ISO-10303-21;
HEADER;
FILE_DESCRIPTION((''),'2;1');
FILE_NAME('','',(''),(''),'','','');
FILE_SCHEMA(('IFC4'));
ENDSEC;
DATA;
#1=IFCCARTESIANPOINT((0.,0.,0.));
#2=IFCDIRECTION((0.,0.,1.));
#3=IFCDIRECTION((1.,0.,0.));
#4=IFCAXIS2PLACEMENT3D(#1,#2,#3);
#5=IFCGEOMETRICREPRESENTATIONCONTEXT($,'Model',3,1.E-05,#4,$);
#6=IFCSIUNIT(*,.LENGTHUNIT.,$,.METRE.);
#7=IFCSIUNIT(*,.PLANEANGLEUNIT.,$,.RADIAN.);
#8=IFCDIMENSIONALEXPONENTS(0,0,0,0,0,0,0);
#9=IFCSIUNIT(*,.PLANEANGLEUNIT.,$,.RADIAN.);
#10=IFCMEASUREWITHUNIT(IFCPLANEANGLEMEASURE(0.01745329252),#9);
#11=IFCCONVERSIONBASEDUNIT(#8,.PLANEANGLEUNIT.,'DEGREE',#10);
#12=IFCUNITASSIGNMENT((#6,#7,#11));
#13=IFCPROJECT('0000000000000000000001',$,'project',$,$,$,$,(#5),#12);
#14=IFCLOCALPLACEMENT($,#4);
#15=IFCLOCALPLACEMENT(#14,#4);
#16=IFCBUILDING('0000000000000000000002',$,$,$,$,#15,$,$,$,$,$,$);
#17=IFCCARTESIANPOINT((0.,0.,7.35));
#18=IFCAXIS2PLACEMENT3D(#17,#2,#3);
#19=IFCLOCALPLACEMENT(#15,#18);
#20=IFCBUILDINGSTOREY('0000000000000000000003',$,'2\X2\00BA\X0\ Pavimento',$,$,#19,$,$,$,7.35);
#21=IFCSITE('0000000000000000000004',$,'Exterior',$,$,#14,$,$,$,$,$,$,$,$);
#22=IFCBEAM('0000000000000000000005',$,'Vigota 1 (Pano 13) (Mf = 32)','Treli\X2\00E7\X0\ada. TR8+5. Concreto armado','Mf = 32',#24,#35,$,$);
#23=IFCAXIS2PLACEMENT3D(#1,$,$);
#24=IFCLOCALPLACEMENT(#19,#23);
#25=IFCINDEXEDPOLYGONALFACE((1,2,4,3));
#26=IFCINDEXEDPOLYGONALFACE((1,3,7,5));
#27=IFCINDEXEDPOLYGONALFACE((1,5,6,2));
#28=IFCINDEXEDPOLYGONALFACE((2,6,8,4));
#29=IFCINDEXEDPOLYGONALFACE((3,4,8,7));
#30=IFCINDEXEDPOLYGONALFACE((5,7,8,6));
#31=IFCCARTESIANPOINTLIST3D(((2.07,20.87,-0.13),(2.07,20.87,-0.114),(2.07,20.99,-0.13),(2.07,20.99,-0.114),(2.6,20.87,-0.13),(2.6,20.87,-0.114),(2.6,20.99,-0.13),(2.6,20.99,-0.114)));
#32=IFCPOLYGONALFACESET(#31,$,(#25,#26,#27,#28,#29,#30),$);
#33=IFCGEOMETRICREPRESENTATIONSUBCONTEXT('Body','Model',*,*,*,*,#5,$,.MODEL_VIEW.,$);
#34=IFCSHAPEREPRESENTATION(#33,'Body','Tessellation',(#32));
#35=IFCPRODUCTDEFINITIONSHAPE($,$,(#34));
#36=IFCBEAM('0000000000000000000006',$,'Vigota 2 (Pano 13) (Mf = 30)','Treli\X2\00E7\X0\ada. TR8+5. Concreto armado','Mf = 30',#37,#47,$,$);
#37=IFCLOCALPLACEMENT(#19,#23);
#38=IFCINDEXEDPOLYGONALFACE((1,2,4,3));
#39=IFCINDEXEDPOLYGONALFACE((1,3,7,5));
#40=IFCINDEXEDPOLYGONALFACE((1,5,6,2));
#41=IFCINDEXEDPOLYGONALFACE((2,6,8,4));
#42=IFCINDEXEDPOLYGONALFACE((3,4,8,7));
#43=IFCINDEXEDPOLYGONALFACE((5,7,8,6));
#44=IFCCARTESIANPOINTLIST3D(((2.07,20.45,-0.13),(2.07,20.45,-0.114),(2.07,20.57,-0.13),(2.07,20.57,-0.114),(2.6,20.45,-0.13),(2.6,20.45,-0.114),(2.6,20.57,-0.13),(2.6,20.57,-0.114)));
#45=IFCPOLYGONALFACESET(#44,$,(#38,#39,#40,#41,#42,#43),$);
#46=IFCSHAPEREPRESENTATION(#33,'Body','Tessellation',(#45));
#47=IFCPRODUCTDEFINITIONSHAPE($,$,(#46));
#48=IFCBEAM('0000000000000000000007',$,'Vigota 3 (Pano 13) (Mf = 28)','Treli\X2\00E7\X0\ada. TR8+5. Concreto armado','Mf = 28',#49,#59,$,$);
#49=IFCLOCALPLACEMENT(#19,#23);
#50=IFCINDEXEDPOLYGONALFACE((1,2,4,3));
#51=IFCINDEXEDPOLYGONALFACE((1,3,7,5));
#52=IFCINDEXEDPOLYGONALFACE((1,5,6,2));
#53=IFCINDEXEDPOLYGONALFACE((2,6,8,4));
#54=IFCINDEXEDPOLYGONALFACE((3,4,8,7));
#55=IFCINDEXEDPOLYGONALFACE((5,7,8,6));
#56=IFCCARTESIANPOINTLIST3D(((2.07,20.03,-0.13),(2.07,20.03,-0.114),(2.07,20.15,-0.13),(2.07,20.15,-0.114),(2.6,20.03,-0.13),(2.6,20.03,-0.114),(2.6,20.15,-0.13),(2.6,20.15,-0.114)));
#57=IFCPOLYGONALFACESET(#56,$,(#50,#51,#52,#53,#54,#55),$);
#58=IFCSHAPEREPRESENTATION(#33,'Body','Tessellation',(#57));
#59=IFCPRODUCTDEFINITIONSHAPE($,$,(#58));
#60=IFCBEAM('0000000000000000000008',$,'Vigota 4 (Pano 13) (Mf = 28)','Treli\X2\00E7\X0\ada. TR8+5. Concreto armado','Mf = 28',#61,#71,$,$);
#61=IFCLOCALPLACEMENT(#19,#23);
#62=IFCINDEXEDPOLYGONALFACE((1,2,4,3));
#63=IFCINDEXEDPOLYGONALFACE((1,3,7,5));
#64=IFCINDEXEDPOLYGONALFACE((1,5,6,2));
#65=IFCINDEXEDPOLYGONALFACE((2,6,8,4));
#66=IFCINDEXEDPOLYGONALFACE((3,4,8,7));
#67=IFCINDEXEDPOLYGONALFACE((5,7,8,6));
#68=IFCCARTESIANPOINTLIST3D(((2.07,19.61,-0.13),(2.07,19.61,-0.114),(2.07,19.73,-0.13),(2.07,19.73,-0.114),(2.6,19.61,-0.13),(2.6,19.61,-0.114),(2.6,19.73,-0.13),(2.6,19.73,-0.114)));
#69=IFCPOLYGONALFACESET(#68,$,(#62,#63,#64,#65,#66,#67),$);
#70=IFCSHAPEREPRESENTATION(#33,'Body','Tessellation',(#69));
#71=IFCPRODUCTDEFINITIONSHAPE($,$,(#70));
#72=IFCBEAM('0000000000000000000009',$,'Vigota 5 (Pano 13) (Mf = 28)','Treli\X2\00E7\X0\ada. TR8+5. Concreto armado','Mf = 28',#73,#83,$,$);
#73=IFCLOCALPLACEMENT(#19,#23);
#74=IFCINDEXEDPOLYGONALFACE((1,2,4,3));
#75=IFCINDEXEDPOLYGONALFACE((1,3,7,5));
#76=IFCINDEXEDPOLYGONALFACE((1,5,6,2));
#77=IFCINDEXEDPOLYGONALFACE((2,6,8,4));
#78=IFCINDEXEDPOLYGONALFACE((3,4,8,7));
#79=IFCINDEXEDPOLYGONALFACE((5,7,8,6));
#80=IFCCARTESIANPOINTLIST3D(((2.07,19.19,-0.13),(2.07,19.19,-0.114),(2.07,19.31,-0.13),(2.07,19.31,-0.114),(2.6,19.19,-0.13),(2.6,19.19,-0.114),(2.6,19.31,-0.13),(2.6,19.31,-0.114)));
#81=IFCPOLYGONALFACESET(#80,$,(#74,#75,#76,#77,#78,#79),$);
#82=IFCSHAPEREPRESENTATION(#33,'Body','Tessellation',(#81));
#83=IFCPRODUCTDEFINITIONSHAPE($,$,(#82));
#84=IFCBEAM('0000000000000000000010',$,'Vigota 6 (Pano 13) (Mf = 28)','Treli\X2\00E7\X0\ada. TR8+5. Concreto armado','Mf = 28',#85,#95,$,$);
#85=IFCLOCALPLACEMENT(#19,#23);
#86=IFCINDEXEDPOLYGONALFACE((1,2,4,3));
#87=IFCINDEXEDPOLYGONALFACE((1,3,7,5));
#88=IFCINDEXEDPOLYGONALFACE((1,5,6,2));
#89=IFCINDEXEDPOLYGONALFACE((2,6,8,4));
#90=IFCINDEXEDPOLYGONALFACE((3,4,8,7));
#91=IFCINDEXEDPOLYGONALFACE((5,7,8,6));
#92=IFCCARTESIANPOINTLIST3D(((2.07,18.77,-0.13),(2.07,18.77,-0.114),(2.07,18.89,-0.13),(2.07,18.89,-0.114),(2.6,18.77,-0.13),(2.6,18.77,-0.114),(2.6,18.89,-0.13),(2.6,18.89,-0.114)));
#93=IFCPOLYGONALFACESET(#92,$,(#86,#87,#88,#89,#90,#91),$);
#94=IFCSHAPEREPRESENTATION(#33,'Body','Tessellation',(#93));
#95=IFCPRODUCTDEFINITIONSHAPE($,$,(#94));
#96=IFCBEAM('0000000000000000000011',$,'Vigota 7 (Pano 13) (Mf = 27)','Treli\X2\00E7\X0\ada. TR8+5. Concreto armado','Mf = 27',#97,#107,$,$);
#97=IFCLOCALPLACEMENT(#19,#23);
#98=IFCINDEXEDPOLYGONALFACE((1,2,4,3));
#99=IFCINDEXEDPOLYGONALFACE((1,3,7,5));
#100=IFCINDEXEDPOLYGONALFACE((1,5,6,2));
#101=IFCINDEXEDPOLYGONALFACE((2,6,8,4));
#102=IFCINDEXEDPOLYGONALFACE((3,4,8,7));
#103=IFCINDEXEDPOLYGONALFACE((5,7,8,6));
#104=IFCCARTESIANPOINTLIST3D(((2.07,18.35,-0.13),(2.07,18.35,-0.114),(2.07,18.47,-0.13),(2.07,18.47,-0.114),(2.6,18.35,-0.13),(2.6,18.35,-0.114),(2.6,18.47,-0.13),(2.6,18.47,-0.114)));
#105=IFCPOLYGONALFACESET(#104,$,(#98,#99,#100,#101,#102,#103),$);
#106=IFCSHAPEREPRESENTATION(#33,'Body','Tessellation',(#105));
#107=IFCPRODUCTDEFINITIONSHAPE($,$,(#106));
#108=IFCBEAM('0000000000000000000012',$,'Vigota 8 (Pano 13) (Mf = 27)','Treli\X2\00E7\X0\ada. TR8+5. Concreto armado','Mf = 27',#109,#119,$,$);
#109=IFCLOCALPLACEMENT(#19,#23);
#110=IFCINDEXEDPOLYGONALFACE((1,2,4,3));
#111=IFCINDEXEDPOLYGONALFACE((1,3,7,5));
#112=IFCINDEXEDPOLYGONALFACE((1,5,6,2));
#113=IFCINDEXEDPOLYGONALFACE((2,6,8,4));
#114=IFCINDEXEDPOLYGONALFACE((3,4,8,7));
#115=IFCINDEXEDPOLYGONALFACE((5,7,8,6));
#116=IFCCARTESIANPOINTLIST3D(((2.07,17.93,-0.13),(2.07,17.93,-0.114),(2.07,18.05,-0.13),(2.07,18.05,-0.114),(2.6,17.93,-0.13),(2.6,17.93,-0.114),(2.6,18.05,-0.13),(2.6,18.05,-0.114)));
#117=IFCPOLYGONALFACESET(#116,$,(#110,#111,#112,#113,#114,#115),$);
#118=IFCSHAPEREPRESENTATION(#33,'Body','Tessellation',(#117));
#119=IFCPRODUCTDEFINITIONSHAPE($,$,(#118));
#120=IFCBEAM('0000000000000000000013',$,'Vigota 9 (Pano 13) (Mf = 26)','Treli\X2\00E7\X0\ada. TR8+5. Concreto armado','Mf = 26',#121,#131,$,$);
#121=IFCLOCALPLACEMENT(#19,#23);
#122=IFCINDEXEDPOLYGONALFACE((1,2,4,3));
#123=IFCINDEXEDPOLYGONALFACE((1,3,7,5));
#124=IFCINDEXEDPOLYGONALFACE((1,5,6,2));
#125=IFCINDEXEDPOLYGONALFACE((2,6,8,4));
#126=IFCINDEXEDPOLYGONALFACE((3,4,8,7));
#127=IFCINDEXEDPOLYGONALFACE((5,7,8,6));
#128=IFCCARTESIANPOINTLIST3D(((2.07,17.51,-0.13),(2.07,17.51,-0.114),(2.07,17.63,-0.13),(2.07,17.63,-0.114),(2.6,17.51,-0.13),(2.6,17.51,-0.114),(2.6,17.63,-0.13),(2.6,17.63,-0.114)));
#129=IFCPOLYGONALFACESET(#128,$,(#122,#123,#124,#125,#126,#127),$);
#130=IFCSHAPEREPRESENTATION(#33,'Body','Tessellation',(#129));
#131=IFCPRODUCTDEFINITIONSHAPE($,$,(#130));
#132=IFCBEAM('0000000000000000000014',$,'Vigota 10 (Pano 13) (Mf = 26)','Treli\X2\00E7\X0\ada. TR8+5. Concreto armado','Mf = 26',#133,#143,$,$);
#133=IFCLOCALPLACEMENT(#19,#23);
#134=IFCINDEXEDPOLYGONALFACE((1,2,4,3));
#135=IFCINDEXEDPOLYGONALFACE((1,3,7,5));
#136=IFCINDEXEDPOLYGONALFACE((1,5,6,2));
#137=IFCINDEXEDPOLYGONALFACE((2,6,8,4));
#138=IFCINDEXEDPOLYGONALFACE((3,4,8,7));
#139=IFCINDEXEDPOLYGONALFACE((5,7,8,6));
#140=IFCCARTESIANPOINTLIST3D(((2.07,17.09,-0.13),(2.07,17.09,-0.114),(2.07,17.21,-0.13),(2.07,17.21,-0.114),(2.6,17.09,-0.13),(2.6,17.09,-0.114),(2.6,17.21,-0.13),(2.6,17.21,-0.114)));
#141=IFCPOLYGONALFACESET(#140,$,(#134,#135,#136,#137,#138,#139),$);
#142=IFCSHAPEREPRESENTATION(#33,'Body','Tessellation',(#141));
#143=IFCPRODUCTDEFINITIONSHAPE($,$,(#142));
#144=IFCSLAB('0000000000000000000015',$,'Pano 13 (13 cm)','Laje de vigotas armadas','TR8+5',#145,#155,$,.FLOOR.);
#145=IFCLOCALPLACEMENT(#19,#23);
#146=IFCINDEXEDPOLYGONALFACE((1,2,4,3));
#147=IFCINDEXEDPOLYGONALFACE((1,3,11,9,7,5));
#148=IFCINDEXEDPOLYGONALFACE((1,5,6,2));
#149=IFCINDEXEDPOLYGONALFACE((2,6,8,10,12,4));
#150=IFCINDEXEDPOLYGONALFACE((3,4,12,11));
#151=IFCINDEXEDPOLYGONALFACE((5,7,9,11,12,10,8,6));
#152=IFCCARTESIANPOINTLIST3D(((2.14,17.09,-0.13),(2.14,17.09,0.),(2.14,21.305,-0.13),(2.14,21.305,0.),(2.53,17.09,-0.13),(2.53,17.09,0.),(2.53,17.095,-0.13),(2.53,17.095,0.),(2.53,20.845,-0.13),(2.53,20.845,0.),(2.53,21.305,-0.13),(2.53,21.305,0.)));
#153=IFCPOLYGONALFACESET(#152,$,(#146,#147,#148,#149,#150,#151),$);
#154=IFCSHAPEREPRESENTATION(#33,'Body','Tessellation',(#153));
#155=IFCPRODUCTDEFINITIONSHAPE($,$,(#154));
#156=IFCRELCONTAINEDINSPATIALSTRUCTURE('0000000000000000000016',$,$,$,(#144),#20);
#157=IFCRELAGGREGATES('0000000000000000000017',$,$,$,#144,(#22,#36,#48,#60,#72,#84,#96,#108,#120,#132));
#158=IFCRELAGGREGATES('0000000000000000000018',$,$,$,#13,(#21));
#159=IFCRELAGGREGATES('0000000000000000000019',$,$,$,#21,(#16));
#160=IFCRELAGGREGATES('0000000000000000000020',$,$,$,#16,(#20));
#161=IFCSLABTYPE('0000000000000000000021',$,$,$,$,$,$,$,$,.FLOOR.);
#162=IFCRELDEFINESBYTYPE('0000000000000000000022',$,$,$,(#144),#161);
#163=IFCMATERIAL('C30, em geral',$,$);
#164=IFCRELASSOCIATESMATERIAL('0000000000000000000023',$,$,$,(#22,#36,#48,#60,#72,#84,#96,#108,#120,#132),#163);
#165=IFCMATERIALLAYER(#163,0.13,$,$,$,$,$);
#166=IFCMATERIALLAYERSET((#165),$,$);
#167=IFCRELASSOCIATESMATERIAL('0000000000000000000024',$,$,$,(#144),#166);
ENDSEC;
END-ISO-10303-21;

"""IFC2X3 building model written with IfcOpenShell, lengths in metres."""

from ifc_helpers import new_model, entity, si_unit, converted_unit, frame, origin_with_axes, place, context, subcontext, project, spatial, polyline, outline, extrude, material, layer, layer_set, layer_usage, type_object, element, aggregate, save


model = new_model("IFC2X3")

# Units and contexts
model_context = context("Model", 3, precision=1e-05, world=origin_with_axes())
body_context = subcontext(model_context, "Body", "Model", "MODEL_VIEW")
ifc_project = project(units=[si_unit("LENGTHUNIT", "METRE"), si_unit("PLANEANGLEUNIT", "RADIAN"), converted_unit("PLANEANGLEUNIT", "DEGREE", entity("IfcPlaneAngleMeasure", 0.01745329252), si_unit("PLANEANGLEUNIT", "RADIAN"), dimensions=[0, 0, 0, 0, 0, 0, 0])], contexts=[model_context])

# Beams
ifc_material = material(Name="C30, em geral")
site_placement = place(None, origin_with_axes())
building_placement = place(site_placement, origin_with_axes())
storey_placement = place(building_placement, frame((0.0, 0.0, 7.35), z_axis=(0.0, 0.0, 1.0), x_axis=(1.0, 0.0, 0.0)))
beam_1_placement = place(storey_placement, frame((2.07, 20.93, -0.122), z_axis=(1.0, 0.0, 0.0), x_axis=(0.0, 1.0, 0.0)))
beam_1 = element("IfcBeam", 1, at=beam_1_placement, material=ifc_material, Name="Vigota 1 (Pano 13) (Mf = 32)", Description="Treliçada. TR8+5. Concreto armado", ObjectType="Mf = 32", context=body_context, shape_type="SweptSolid", body=[
    extrude(outline(polyline([(0.06, 0.008), (-0.06, 0.008), (-0.06, -0.008), (0.06, -0.008), (0.06, 0.008)])), origin_with_axes(), (0.0, 0.0, 1.0), 0.53),
])
beam_2_placement = place(storey_placement, frame((2.07, 20.51, -0.122), z_axis=(1.0, 0.0, 0.0), x_axis=(0.0, 1.0, 0.0)))
beam_2 = element("IfcBeam", 2, at=beam_2_placement, material=ifc_material, Name="Vigota 2 (Pano 13) (Mf = 30)", Description="Treliçada. TR8+5. Concreto armado", ObjectType="Mf = 30", context=body_context, shape_type="SweptSolid", body=[
    extrude(outline(polyline([(0.06, 0.008), (-0.06, 0.008), (-0.06, -0.008), (0.06, -0.008), (0.06, 0.008)])), origin_with_axes(), (0.0, 0.0, 1.0), 0.53),
])
beam_3_placement = place(storey_placement, frame((2.07, 20.09, -0.122), z_axis=(1.0, 0.0, 0.0), x_axis=(0.0, 1.0, 0.0)))
beam_3 = element("IfcBeam", 3, at=beam_3_placement, material=ifc_material, Name="Vigota 3 (Pano 13) (Mf = 28)", Description="Treliçada. TR8+5. Concreto armado", ObjectType="Mf = 28", context=body_context, shape_type="SweptSolid", body=[
    extrude(outline(polyline([(0.06, 0.008), (-0.06, 0.008), (-0.06, -0.008), (0.06, -0.008), (0.06, 0.008)])), origin_with_axes(), (0.0, 0.0, 1.0), 0.53),
])
beam_4_placement = place(storey_placement, frame((2.07, 19.67, -0.122), z_axis=(1.0, 0.0, 0.0), x_axis=(0.0, 1.0, 0.0)))
beam_4 = element("IfcBeam", 4, at=beam_4_placement, material=ifc_material, Name="Vigota 4 (Pano 13) (Mf = 28)", Description="Treliçada. TR8+5. Concreto armado", ObjectType="Mf = 28", context=body_context, shape_type="SweptSolid", body=[
    extrude(outline(polyline([(0.06, 0.008), (-0.06, 0.008), (-0.06, -0.008), (0.06, -0.008), (0.06, 0.008)])), origin_with_axes(), (0.0, 0.0, 1.0), 0.53),
])
beam_5_placement = place(storey_placement, frame((2.07, 19.25, -0.122), z_axis=(1.0, 0.0, 0.0), x_axis=(0.0, 1.0, 0.0)))
beam_5 = element("IfcBeam", 5, at=beam_5_placement, material=ifc_material, Name="Vigota 5 (Pano 13) (Mf = 28)", Description="Treliçada. TR8+5. Concreto armado", ObjectType="Mf = 28", context=body_context, shape_type="SweptSolid", body=[
    extrude(outline(polyline([(0.06, 0.008), (-0.06, 0.008), (-0.06, -0.008), (0.06, -0.008), (0.06, 0.008)])), origin_with_axes(), (0.0, 0.0, 1.0), 0.53),
])
beam_6_placement = place(storey_placement, frame((2.07, 18.83, -0.122), z_axis=(1.0, 0.0, 0.0), x_axis=(0.0, 1.0, 0.0)))
beam_6 = element("IfcBeam", 6, at=beam_6_placement, material=ifc_material, Name="Vigota 6 (Pano 13) (Mf = 28)", Description="Treliçada. TR8+5. Concreto armado", ObjectType="Mf = 28", context=body_context, shape_type="SweptSolid", body=[
    extrude(outline(polyline([(0.06, 0.008), (-0.06, 0.008), (-0.06, -0.008), (0.06, -0.008), (0.06, 0.008)])), origin_with_axes(), (0.0, 0.0, 1.0), 0.53),
])
beam_7_placement = place(storey_placement, frame((2.07, 18.41, -0.122), z_axis=(1.0, 0.0, 0.0), x_axis=(0.0, 1.0, 0.0)))
beam_7 = element("IfcBeam", 7, at=beam_7_placement, material=ifc_material, Name="Vigota 7 (Pano 13) (Mf = 27)", Description="Treliçada. TR8+5. Concreto armado", ObjectType="Mf = 27", context=body_context, shape_type="SweptSolid", body=[
    extrude(outline(polyline([(0.06, 0.008), (-0.06, 0.008), (-0.06, -0.008), (0.06, -0.008), (0.06, 0.008)])), origin_with_axes(), (0.0, 0.0, 1.0), 0.53),
])
beam_8_placement = place(storey_placement, frame((2.07, 17.99, -0.122), z_axis=(1.0, 0.0, 0.0), x_axis=(0.0, 1.0, 0.0)))
beam_8 = element("IfcBeam", 8, at=beam_8_placement, material=ifc_material, Name="Vigota 8 (Pano 13) (Mf = 27)", Description="Treliçada. TR8+5. Concreto armado", ObjectType="Mf = 27", context=body_context, shape_type="SweptSolid", body=[
    extrude(outline(polyline([(0.06, 0.008), (-0.06, 0.008), (-0.06, -0.008), (0.06, -0.008), (0.06, 0.008)])), origin_with_axes(), (0.0, 0.0, 1.0), 0.53),
])
beam_9_placement = place(storey_placement, frame((2.07, 17.57, -0.122), z_axis=(1.0, 0.0, 0.0), x_axis=(0.0, 1.0, 0.0)))
beam_9 = element("IfcBeam", 9, at=beam_9_placement, material=ifc_material, Name="Vigota 9 (Pano 13) (Mf = 26)", Description="Treliçada. TR8+5. Concreto armado", ObjectType="Mf = 26", context=body_context, shape_type="SweptSolid", body=[
    extrude(outline(polyline([(0.06, 0.008), (-0.06, 0.008), (-0.06, -0.008), (0.06, -0.008), (0.06, 0.008)])), origin_with_axes(), (0.0, 0.0, 1.0), 0.53),
])
beam_10_placement = place(storey_placement, frame((2.07, 17.15, -0.122), z_axis=(1.0, 0.0, 0.0), x_axis=(0.0, 1.0, 0.0)))
beam_10 = element("IfcBeam", 10, at=beam_10_placement, material=ifc_material, Name="Vigota 10 (Pano 13) (Mf = 26)", Description="Treliçada. TR8+5. Concreto armado", ObjectType="Mf = 26", context=body_context, shape_type="SweptSolid", body=[
    extrude(outline(polyline([(0.06, 0.008), (-0.06, 0.008), (-0.06, -0.008), (0.06, -0.008), (0.06, 0.008)])), origin_with_axes(), (0.0, 0.0, 1.0), 0.53),
])

# Site, building, storey
site = spatial("IfcSite", under=ifc_project, at=site_placement, Name="Exterior")
building = spatial("IfcBuilding", under=site, at=building_placement)
storey = spatial("IfcBuildingStorey", under=building, at=storey_placement, Name="2º Pavimento", Elevation=7.35)

# Slab
slab_type = type_object("IfcSlabType", PredefinedType="FLOOR")
ifc_layer_1 = layer(ifc_material, 0.13)
ifc_layer_set_1 = layer_set([ifc_layer_1])
ifc_layer_usage_1 = layer_usage(ifc_layer_set_1, "AXIS3", "POSITIVE", 0.0)
slab_1_placement = place(storey_placement, frame((0.0, 0.0, -0.13), z_axis=(0.0, 0.0, 1.0), x_axis=(1.0, 0.0, 0.0)))
slab_1 = element("IfcSlab", 11, at=slab_1_placement, inside=storey, type_object=slab_type, material=ifc_layer_usage_1, Name="Pano 13 (13 cm)", Description="Laje de vigotas armadas", ObjectType="TR8+5", PredefinedType="FLOOR", context=body_context, shape_type="SweptSolid", body=[
    extrude(outline(polyline([(2.53, 21.305), (2.14, 21.305), (2.14, 17.09), (2.53, 17.09), (2.53, 17.095), (2.53, 20.845), (2.53, 21.305)])), origin_with_axes(), (0.0, 0.0, 1.0), 0.13),
])
aggregate(slab_1, [beam_1, beam_2, beam_3, beam_4, beam_5, beam_6, beam_7, beam_8, beam_9, beam_10])

save(model, "model.ifc")
